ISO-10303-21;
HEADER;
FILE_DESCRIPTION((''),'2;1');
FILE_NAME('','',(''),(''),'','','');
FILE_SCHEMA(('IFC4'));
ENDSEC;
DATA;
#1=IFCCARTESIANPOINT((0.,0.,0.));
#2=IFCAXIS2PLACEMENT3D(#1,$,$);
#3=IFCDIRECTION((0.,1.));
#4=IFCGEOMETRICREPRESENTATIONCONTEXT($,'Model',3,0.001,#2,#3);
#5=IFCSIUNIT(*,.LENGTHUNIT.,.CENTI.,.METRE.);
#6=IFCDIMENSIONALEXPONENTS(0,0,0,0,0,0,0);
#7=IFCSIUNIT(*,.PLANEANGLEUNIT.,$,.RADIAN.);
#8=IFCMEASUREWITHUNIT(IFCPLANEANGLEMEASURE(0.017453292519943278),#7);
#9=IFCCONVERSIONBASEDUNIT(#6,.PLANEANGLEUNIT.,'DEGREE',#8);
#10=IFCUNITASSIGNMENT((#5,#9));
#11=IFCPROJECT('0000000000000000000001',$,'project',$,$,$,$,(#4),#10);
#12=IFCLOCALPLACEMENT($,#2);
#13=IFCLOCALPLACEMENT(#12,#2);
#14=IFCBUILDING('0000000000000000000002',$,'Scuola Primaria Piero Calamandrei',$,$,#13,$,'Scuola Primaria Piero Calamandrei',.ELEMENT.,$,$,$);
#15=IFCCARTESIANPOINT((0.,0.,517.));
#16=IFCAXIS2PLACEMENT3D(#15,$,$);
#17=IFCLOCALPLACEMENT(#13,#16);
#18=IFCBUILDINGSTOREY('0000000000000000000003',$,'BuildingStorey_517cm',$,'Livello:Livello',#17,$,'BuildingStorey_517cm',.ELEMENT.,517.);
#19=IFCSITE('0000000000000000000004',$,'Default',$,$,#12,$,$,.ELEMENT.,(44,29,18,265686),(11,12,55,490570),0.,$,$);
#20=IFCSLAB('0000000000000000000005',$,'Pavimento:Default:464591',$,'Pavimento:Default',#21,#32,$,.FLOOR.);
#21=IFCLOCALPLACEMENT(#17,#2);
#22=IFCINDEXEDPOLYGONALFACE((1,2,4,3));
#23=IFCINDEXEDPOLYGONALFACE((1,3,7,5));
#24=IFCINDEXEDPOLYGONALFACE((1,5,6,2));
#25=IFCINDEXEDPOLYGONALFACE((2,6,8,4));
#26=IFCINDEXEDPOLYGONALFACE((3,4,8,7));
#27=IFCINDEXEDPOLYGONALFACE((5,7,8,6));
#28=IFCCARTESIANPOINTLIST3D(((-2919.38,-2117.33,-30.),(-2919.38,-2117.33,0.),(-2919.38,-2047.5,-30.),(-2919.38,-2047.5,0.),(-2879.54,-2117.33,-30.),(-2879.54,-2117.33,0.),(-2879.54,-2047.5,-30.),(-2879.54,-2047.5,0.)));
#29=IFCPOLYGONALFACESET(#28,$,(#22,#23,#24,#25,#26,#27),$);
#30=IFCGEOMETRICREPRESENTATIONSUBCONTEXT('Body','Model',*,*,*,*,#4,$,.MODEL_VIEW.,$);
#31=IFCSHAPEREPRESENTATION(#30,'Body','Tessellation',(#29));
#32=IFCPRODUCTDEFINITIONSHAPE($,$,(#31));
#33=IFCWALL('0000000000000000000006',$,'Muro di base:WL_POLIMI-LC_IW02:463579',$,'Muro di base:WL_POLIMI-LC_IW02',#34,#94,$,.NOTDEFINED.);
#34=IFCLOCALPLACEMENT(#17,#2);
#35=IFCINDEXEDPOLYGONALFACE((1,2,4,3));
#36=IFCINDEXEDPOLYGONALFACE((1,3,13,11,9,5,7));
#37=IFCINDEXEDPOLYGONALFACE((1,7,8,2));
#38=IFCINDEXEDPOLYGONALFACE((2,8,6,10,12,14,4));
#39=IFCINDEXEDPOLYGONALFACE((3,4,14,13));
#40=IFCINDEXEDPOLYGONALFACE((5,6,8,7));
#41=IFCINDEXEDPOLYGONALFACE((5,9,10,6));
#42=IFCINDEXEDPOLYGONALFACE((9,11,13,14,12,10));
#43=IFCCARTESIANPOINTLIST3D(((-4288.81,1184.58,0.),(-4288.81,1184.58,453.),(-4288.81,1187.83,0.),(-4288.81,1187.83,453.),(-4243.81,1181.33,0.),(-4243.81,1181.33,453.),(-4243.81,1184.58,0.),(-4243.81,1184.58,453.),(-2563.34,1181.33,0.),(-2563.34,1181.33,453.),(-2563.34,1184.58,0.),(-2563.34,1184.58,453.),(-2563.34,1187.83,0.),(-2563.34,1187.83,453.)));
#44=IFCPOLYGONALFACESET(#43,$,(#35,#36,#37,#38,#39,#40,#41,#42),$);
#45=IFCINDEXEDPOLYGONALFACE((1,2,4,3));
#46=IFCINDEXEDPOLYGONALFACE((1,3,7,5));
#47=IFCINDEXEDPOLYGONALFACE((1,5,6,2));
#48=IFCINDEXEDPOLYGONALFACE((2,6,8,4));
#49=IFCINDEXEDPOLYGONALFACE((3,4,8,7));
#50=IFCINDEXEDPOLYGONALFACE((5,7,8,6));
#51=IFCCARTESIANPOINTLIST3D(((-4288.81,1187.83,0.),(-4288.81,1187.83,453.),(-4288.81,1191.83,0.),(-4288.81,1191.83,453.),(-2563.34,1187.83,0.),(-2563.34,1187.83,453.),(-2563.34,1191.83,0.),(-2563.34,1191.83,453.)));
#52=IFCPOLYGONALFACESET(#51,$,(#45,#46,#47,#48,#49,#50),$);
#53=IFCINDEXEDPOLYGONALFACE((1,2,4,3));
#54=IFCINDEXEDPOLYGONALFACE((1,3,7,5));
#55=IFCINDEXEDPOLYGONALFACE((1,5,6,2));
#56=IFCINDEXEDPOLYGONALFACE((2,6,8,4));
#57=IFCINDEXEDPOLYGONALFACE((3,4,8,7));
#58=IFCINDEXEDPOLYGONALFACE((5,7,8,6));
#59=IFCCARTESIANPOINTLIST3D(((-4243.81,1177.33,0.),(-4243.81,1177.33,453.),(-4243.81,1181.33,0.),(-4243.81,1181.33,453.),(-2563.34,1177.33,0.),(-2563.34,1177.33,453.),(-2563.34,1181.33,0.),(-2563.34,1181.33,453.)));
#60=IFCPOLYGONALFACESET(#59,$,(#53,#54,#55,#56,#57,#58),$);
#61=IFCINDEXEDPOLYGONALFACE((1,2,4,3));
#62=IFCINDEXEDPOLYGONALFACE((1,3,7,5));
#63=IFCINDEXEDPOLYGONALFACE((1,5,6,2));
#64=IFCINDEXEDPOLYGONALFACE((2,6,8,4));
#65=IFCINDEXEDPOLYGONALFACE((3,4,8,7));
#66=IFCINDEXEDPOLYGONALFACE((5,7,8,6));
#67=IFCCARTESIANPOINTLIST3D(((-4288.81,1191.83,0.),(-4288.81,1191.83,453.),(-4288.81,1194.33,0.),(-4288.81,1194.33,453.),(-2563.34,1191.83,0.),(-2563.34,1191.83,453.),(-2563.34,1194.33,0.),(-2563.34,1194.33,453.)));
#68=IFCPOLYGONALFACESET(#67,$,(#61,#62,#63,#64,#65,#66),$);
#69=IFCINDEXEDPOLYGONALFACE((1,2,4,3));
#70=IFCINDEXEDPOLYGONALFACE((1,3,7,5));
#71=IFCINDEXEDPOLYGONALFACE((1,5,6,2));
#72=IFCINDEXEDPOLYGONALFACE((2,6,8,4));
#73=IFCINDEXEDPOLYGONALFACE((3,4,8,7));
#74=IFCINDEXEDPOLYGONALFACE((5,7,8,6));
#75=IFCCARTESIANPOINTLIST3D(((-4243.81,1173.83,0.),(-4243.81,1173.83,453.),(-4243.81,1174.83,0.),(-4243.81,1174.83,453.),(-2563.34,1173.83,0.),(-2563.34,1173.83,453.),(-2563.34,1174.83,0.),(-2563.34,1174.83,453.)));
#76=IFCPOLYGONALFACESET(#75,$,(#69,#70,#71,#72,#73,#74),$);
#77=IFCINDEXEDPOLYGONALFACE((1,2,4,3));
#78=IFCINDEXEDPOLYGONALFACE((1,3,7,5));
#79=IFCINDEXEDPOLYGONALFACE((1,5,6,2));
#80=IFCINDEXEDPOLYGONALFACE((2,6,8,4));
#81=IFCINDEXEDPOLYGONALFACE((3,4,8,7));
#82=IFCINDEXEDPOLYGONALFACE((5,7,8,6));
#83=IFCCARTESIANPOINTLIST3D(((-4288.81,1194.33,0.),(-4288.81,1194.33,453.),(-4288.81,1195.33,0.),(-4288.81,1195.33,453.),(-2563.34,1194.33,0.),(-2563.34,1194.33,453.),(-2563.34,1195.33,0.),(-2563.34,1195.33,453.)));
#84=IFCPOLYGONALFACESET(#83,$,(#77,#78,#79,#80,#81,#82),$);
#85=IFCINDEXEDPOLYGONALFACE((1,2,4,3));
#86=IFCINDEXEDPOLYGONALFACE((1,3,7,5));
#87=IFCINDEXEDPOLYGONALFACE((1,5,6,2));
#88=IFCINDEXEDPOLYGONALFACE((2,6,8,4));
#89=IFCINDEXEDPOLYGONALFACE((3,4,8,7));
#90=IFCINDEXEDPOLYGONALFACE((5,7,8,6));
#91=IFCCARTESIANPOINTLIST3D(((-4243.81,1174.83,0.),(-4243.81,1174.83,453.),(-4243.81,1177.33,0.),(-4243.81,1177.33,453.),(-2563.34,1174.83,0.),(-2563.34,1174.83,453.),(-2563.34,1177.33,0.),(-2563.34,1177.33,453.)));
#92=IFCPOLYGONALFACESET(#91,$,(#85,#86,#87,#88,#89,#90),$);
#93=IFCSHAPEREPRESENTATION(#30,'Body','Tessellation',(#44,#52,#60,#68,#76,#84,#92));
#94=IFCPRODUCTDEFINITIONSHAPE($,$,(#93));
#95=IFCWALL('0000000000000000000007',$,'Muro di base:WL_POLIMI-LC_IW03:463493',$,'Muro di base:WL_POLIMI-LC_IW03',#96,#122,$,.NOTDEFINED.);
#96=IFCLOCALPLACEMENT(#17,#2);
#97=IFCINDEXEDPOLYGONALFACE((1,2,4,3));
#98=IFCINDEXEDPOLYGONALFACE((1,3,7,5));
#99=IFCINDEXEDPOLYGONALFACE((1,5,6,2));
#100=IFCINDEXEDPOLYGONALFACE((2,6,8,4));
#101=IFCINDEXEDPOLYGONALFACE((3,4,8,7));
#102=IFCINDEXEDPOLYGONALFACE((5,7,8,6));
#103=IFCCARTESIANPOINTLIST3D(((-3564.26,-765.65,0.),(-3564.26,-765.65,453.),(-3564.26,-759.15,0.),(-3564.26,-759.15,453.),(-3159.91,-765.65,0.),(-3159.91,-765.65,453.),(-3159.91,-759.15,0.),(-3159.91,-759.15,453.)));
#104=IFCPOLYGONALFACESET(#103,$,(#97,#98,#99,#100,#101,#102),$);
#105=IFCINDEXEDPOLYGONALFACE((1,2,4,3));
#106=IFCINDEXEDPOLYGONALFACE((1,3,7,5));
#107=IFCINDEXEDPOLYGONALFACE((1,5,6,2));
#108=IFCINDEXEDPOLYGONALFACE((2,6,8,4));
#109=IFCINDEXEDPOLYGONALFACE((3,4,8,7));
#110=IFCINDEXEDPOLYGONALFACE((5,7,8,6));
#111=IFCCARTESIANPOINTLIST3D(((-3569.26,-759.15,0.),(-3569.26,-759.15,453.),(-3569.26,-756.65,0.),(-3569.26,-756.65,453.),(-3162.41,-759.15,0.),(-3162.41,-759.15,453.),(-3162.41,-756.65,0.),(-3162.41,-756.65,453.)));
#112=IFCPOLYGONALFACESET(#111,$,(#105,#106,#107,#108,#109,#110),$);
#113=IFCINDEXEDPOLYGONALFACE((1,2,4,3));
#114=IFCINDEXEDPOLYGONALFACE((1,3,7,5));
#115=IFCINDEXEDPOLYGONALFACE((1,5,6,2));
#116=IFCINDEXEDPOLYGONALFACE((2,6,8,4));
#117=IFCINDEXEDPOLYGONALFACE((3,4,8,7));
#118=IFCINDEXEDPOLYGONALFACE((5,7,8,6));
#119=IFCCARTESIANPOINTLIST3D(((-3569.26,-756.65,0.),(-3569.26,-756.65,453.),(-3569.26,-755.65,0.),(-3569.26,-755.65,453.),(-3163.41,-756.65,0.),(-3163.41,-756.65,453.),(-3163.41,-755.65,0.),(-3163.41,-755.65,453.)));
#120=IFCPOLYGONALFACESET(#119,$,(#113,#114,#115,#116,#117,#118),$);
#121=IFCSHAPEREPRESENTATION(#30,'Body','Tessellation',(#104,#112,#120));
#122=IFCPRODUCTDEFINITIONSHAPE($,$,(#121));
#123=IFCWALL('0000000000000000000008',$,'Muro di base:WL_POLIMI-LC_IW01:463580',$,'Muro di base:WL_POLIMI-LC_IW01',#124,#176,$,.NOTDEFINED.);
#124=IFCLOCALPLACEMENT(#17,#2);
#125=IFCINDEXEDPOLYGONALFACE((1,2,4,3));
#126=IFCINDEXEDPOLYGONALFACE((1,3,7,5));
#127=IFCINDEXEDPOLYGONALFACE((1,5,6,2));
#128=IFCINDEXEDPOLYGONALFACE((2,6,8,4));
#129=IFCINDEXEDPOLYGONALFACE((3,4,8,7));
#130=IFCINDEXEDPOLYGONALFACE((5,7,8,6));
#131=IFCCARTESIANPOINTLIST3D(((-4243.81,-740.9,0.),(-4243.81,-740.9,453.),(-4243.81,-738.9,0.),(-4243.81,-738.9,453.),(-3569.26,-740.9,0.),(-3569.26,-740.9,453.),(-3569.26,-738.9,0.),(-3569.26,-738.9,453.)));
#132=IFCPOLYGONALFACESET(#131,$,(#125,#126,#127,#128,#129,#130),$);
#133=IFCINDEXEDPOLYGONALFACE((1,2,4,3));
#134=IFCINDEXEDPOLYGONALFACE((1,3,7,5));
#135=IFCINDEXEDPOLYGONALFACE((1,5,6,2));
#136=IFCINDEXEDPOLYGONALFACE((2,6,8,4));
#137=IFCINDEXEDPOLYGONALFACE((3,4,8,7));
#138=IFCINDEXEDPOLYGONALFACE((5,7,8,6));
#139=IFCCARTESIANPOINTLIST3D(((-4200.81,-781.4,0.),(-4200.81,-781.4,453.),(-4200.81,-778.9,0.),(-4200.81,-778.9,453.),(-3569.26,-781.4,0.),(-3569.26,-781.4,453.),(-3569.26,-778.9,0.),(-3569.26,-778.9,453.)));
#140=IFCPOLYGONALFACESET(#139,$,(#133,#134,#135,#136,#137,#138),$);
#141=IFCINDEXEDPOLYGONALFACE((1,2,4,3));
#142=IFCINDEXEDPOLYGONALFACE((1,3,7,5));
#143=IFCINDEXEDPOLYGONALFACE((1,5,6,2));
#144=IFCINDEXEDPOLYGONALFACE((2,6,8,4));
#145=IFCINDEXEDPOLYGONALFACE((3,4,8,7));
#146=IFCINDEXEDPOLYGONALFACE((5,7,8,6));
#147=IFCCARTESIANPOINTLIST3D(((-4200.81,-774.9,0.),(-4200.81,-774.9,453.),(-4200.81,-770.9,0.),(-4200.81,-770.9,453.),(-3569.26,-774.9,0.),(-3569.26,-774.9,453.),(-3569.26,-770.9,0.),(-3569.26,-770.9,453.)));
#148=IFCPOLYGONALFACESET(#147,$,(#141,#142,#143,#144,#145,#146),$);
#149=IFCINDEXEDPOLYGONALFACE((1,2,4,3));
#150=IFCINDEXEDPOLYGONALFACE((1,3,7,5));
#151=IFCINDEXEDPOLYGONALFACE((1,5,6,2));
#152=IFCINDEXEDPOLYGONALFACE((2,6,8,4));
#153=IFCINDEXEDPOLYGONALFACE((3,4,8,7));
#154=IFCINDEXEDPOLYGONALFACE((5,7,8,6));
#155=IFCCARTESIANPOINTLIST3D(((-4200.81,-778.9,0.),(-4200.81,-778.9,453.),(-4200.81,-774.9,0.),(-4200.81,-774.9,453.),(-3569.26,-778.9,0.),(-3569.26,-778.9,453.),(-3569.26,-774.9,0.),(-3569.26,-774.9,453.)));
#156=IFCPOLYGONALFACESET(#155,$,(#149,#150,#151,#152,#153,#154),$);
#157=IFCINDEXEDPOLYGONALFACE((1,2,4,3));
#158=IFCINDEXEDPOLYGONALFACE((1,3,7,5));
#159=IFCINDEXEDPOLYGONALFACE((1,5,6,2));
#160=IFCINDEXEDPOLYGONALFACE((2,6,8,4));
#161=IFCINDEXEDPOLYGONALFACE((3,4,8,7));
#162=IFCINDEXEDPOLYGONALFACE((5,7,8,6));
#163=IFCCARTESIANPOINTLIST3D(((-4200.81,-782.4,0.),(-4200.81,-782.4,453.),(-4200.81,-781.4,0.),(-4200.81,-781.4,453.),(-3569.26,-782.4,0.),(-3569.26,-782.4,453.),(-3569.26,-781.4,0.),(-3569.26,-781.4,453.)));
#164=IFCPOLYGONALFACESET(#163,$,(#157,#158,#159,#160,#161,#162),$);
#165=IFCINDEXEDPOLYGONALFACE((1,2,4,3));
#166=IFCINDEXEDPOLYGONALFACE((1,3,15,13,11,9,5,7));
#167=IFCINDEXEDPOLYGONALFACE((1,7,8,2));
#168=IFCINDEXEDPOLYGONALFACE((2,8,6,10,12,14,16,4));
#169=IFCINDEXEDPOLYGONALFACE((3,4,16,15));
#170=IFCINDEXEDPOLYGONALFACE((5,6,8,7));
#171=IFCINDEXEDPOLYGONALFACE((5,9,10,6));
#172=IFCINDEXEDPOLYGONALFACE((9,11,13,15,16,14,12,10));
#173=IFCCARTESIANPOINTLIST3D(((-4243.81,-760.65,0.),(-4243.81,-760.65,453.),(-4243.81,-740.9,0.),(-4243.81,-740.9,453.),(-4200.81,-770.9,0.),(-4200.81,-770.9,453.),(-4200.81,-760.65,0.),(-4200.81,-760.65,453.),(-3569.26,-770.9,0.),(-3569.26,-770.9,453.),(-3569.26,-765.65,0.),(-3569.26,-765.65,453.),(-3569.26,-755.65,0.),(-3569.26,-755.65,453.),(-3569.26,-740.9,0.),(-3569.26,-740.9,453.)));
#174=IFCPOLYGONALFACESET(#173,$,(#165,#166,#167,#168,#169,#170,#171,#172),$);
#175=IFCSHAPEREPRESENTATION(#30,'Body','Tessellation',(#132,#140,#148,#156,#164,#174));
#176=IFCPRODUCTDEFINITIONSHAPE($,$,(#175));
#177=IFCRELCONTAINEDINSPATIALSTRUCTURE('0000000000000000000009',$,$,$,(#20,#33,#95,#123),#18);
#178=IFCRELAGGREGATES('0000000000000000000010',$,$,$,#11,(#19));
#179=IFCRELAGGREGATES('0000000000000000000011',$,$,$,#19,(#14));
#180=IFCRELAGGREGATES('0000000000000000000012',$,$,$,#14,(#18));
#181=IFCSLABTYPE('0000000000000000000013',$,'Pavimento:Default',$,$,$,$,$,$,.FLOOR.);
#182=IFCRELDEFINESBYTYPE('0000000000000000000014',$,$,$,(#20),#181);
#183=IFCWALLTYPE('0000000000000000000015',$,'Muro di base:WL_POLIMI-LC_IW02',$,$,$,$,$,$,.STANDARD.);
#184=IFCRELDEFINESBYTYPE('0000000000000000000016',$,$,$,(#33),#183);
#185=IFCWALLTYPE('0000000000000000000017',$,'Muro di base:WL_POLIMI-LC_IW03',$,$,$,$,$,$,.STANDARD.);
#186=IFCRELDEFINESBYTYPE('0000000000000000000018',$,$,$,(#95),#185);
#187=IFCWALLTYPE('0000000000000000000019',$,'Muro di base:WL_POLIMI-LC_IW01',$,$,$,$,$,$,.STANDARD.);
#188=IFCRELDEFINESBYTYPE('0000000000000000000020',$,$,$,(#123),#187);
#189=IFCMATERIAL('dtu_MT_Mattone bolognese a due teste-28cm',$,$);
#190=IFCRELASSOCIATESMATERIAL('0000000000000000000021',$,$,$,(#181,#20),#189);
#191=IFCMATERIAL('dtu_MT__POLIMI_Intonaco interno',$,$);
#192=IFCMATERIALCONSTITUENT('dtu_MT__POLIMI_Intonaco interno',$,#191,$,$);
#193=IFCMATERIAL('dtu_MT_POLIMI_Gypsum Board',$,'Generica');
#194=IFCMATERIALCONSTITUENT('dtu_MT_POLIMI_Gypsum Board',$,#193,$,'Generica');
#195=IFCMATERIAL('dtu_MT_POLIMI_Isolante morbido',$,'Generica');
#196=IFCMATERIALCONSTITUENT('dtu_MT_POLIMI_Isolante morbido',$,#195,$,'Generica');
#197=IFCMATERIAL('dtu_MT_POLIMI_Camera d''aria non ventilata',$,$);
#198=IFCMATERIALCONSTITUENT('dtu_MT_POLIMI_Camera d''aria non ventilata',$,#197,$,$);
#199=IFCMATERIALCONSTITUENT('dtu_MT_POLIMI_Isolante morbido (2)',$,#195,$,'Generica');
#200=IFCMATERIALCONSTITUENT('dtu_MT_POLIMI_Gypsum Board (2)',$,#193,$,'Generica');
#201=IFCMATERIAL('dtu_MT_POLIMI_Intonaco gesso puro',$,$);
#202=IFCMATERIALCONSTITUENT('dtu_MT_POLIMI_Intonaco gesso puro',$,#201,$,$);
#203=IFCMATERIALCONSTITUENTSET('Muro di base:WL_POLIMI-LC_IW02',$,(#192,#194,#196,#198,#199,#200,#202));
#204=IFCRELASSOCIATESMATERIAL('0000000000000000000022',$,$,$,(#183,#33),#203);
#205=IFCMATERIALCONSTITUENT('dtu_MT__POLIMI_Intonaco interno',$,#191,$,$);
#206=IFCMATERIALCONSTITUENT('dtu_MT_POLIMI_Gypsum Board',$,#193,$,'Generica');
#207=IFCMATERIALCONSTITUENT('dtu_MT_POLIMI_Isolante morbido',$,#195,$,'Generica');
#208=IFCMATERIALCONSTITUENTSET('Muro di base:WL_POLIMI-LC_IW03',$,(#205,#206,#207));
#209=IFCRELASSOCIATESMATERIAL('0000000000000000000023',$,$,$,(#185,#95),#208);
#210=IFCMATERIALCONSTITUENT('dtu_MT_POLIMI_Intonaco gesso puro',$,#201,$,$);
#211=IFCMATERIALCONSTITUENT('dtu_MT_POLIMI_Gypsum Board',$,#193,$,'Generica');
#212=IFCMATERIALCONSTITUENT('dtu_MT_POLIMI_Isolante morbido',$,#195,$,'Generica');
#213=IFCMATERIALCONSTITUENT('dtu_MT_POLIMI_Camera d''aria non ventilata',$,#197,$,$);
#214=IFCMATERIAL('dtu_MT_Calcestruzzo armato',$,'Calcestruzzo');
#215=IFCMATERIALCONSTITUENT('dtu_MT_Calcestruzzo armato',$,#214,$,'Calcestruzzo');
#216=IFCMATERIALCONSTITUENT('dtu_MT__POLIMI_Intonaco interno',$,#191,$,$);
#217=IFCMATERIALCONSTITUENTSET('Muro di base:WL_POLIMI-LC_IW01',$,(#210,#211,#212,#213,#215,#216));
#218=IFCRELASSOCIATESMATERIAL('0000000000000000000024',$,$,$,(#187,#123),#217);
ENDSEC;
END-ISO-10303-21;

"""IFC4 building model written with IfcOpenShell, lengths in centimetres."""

from ifc_helpers import new_model, entity, si_unit, converted_unit, direction, frame, origin, place, context, subcontext, project, spatial, indexed_curve, outline, extrude, material, constituent, constituent_set, type_object, element, save


model = new_model("IFC4")

# Units and contexts
model_context = context("Model", 3, precision=0.001, world=origin(), true_north=direction((0.0, 1.0)))
body_context = subcontext(model_context, "Body", "Model", "MODEL_VIEW")
ifc_project = project(units=[si_unit("LENGTHUNIT", "METRE", prefix="CENTI"), converted_unit("PLANEANGLEUNIT", "DEGREE", entity("IfcPlaneAngleMeasure", 0.017453292519943278), si_unit("PLANEANGLEUNIT", "RADIAN"), dimensions=[0, 0, 0, 0, 0, 0, 0])], contexts=[model_context])

# Site, building, storey
site_placement = place(None, origin())
site = spatial("IfcSite", under=ifc_project, at=site_placement, Name="Default", CompositionType="ELEMENT", RefLatitude=(44, 29, 18, 265686), RefLongitude=(11, 12, 55, 490570), RefElevation=0.0)
building_placement = place(site_placement, origin())
building = spatial("IfcBuilding", under=site, at=building_placement, Name="Scuola Primaria Piero Calamandrei", LongName="Scuola Primaria Piero Calamandrei", CompositionType="ELEMENT")
storey_placement = place(building_placement, frame((0.0, 0.0, 517.0)))
storey = spatial("IfcBuildingStorey", under=building, at=storey_placement, Name="BuildingStorey_517cm", ObjectType="Livello:Livello", LongName="BuildingStorey_517cm", CompositionType="ELEMENT", Elevation=517.0)

# Slab
ifc_material_1 = material(Name="dtu_MT__POLIMI_Intonaco interno")
ifc_material_2 = material(Name="dtu_MT_Mattone bolognese a due teste-28cm")
slab_type_1 = type_object("IfcSlabType", Name="Pavimento:Default", PredefinedType="FLOOR", material=ifc_material_2)
slab_1_placement = place(storey_placement, origin())
element("IfcSlab", 1, at=slab_1_placement, inside=storey, type_object=slab_type_1, material=ifc_material_2, Name="Pavimento:Default:464591", ObjectType="Pavimento:Default", PredefinedType="FLOOR", context=body_context, shape_type="SweptSolid", body=[
    extrude(outline(indexed_curve([(-34.91, -19.92), (34.91, -19.92), (34.91, 19.92), (-34.91, 19.92), (-34.91, -19.92)], self_intersect=False)), frame((-2899.46, -2082.41, 0.0), z_axis=(0.0, 0.0, -1.0), x_axis=(0.0, 1.0, 0.0)), (0.0, 0.0, 1.0), 30.0),
])

# Shared definitions
ifc_material_3 = material(Name="dtu_MT_POLIMI_Isolante morbido", Category="Generica")
ifc_material_4 = material(Name="dtu_MT_POLIMI_Gypsum Board", Category="Generica")
ifc_constituent_1 = constituent(ifc_material_1, Name="dtu_MT__POLIMI_Intonaco interno")
ifc_constituent_2 = constituent(ifc_material_4, Name="dtu_MT_POLIMI_Gypsum Board", Category="Generica")
ifc_constituent_3 = constituent(ifc_material_3, Name="dtu_MT_POLIMI_Isolante morbido", Category="Generica")
ifc_material_5 = material(Name="dtu_MT_POLIMI_Camera d'aria non ventilata")
ifc_constituent_4 = constituent(ifc_material_5, Name="dtu_MT_POLIMI_Camera d'aria non ventilata")
ifc_constituent_5 = constituent(ifc_material_3, Name="dtu_MT_POLIMI_Isolante morbido (2)", Category="Generica")
ifc_constituent_6 = constituent(ifc_material_4, Name="dtu_MT_POLIMI_Gypsum Board (2)", Category="Generica")
ifc_material_6 = material(Name="dtu_MT_POLIMI_Intonaco gesso puro")
ifc_constituent_7 = constituent(ifc_material_6, Name="dtu_MT_POLIMI_Intonaco gesso puro")
ifc_constituent_set_1 = constituent_set(constituents=[ifc_constituent_1, ifc_constituent_2, ifc_constituent_3, ifc_constituent_4, ifc_constituent_5, ifc_constituent_6, ifc_constituent_7], Name="Muro di base:WL_POLIMI-LC_IW02")
wall_type_1 = type_object("IfcWallType", Name="Muro di base:WL_POLIMI-LC_IW02", PredefinedType="STANDARD", material=ifc_constituent_set_1)

# Walls
wall_1_placement = place(storey_placement, frame((-4288.81, 1184.58, 0.0)))
element("IfcWall", 2, at=wall_1_placement, inside=storey, type_object=wall_type_1, material=ifc_constituent_set_1, Name="Muro di base:WL_POLIMI-LC_IW02:463579", ObjectType="Muro di base:WL_POLIMI-LC_IW02", PredefinedType="NOTDEFINED", context=body_context, shape_type="SweptSolid", body=[
    extrude(outline(indexed_curve([(0.0, -707.35), (3.25, -707.35), (3.25, 973.13), (0.0, 973.13), (-3.25, 973.13), (-3.25, -752.35), (0.0, -752.35), (0.0, -707.35)], self_intersect=False)), frame((752.35, 0.0, 0.0), z_axis=(0.0, 0.0, 1.0), x_axis=(0.0, -1.0, 0.0)), (0.0, 0.0, 1.0), 453.0),
    extrude(outline(indexed_curve([(-862.74, -2.0), (862.74, -2.0), (862.74, 2.0), (-862.74, 2.0), (-862.74, -2.0)], self_intersect=False)), frame((862.74, 5.25, 0.0)), (0.0, 0.0, 1.0), 453.0),
    extrude(outline(indexed_curve([(-840.24, -2.0), (840.24, -2.0), (840.24, 2.0), (-840.24, 2.0), (-840.24, -2.0)], self_intersect=False)), frame((885.24, -5.25, 0.0)), (0.0, 0.0, 1.0), 453.0),
    extrude(outline(indexed_curve([(-862.74, -1.25), (862.74, -1.25), (862.74, 1.25), (-862.74, 1.25), (-862.74, -1.25)], self_intersect=False)), frame((862.74, 8.5, 0.0)), (0.0, 0.0, 1.0), 453.0),
    extrude(outline(indexed_curve([(-0.5, -840.24), (0.5, -840.24), (0.5, 840.24), (-0.5, 840.24), (-0.5, -840.24)], self_intersect=False)), frame((885.24, -10.25, 0.0), z_axis=(0.0, 0.0, 1.0), x_axis=(0.0, 1.0, 0.0)), (0.0, 0.0, 1.0), 453.0),
    extrude(outline(indexed_curve([(-0.5, -862.74), (0.5, -862.74), (0.5, 862.74), (-0.5, 862.74), (-0.5, -862.74)], self_intersect=False)), frame((862.74, 10.25, 0.0), z_axis=(0.0, 0.0, 1.0), x_axis=(0.0, -1.0, 0.0)), (0.0, 0.0, 1.0), 453.0),
    extrude(outline(indexed_curve([(-840.24, -1.25), (840.24, -1.25), (840.24, 1.25), (-840.24, 1.25), (-840.24, -1.25)], self_intersect=False)), frame((885.24, -8.5, 0.0)), (0.0, 0.0, 1.0), 453.0),
])
ifc_constituent_8 = constituent(ifc_material_1, Name="dtu_MT__POLIMI_Intonaco interno")
ifc_constituent_9 = constituent(ifc_material_4, Name="dtu_MT_POLIMI_Gypsum Board", Category="Generica")
ifc_constituent_10 = constituent(ifc_material_3, Name="dtu_MT_POLIMI_Isolante morbido", Category="Generica")
ifc_constituent_set_2 = constituent_set(constituents=[ifc_constituent_8, ifc_constituent_9, ifc_constituent_10], Name="Muro di base:WL_POLIMI-LC_IW03")
wall_type_2 = type_object("IfcWallType", Name="Muro di base:WL_POLIMI-LC_IW03", PredefinedType="STANDARD", material=ifc_constituent_set_2)
wall_2_placement = place(storey_placement, frame((-3569.26, -760.65, 0.0)))
element("IfcWall", 3, at=wall_2_placement, inside=storey, type_object=wall_type_2, material=ifc_constituent_set_2, Name="Muro di base:WL_POLIMI-LC_IW03:463493", ObjectType="Muro di base:WL_POLIMI-LC_IW03", PredefinedType="NOTDEFINED", context=body_context, shape_type="SweptSolid", body=[
    extrude(outline(indexed_curve([(-202.17, -3.25), (202.17, -3.25), (202.17, 3.25), (-202.17, 3.25), (-202.17, -3.25)], self_intersect=False)), frame((207.17, -1.75, 0.0)), (0.0, 0.0, 1.0), 453.0),
    extrude(outline(indexed_curve([(-203.42, -1.25), (203.42, -1.25), (203.42, 1.25), (-203.42, 1.25), (-203.42, -1.25)], self_intersect=False)), frame((203.42, 2.75, 0.0)), (0.0, 0.0, 1.0), 453.0),
    extrude(outline(indexed_curve([(-0.5, -202.92), (0.5, -202.92), (0.5, 202.92), (-0.5, 202.92), (-0.5, -202.92)], self_intersect=False)), frame((202.92, 4.5, 0.0), z_axis=(0.0, 0.0, 1.0), x_axis=(0.0, -1.0, 0.0)), (0.0, 0.0, 1.0), 453.0),
])
ifc_constituent_11 = constituent(ifc_material_6, Name="dtu_MT_POLIMI_Intonaco gesso puro")
ifc_constituent_12 = constituent(ifc_material_4, Name="dtu_MT_POLIMI_Gypsum Board", Category="Generica")
ifc_constituent_13 = constituent(ifc_material_3, Name="dtu_MT_POLIMI_Isolante morbido", Category="Generica")
ifc_constituent_14 = constituent(ifc_material_5, Name="dtu_MT_POLIMI_Camera d'aria non ventilata")
ifc_material_7 = material(Name="dtu_MT_Calcestruzzo armato", Category="Calcestruzzo")
ifc_constituent_15 = constituent(ifc_material_7, Name="dtu_MT_Calcestruzzo armato", Category="Calcestruzzo")
ifc_constituent_16 = constituent(ifc_material_1, Name="dtu_MT__POLIMI_Intonaco interno")
ifc_constituent_set_3 = constituent_set(constituents=[ifc_constituent_11, ifc_constituent_12, ifc_constituent_13, ifc_constituent_14, ifc_constituent_15, ifc_constituent_16], Name="Muro di base:WL_POLIMI-LC_IW01")
wall_type_3 = type_object("IfcWallType", Name="Muro di base:WL_POLIMI-LC_IW01", PredefinedType="STANDARD", material=ifc_constituent_set_3)
wall_3_placement = place(storey_placement, frame((-3569.26, -760.65, 0.0), z_axis=(0.0, 0.0, 1.0), x_axis=(-1.0, 0.0, 0.0)))
element("IfcWall", 4, at=wall_3_placement, inside=storey, type_object=wall_type_3, material=ifc_constituent_set_3, Name="Muro di base:WL_POLIMI-LC_IW01:463580", ObjectType="Muro di base:WL_POLIMI-LC_IW01", PredefinedType="NOTDEFINED", context=body_context, shape_type="SweptSolid", body=[
    extrude(outline(indexed_curve([(-1.0, -337.28), (1.0, -337.28), (1.0, 337.28), (-1.0, 337.28), (-1.0, -337.28)], self_intersect=False)), frame((337.28, -20.75, 0.0), z_axis=(0.0, 0.0, 1.0), x_axis=(0.0, 1.0, 0.0)), (0.0, 0.0, 1.0), 453.0),
    extrude(outline(indexed_curve([(-315.78, -1.25), (315.78, -1.25), (315.78, 1.25), (-315.78, 1.25), (-315.78, -1.25)], self_intersect=False)), frame((315.78, 19.5, 0.0)), (0.0, 0.0, 1.0), 453.0),
    extrude(outline(indexed_curve([(-315.78, -2.0), (315.78, -2.0), (315.78, 2.0), (-315.78, 2.0), (-315.78, -2.0)], self_intersect=False)), frame((315.78, 12.25, 0.0)), (0.0, 0.0, 1.0), 453.0),
    extrude(outline(indexed_curve([(-315.78, -2.0), (315.78, -2.0), (315.78, 2.0), (-315.78, 2.0), (-315.78, -2.0)], self_intersect=False)), frame((315.78, 16.25, 0.0)), (0.0, 0.0, 1.0), 453.0),
    extrude(outline(indexed_curve([(-0.5, -315.78), (0.5, -315.78), (0.5, 315.78), (-0.5, 315.78), (-0.5, -315.78)], self_intersect=False)), frame((315.78, 21.25, 0.0), z_axis=(0.0, 0.0, 1.0), x_axis=(0.0, -1.0, 0.0)), (0.0, 0.0, 1.0), 453.0),
    extrude(outline(indexed_curve([(2.63, -326.53), (17.37, -326.53), (17.37, 348.03), (-2.38, 348.03), (-2.38, 305.03), (-12.62, 305.03), (-12.62, -326.53), (-7.37, -326.53), (2.63, -326.53)], self_intersect=False)), frame((326.53, -2.38, 0.0), z_axis=(0.0, 0.0, 1.0), x_axis=(0.0, -1.0, 0.0)), (0.0, 0.0, 1.0), 453.0),
])

save(model, "model.ifc")
